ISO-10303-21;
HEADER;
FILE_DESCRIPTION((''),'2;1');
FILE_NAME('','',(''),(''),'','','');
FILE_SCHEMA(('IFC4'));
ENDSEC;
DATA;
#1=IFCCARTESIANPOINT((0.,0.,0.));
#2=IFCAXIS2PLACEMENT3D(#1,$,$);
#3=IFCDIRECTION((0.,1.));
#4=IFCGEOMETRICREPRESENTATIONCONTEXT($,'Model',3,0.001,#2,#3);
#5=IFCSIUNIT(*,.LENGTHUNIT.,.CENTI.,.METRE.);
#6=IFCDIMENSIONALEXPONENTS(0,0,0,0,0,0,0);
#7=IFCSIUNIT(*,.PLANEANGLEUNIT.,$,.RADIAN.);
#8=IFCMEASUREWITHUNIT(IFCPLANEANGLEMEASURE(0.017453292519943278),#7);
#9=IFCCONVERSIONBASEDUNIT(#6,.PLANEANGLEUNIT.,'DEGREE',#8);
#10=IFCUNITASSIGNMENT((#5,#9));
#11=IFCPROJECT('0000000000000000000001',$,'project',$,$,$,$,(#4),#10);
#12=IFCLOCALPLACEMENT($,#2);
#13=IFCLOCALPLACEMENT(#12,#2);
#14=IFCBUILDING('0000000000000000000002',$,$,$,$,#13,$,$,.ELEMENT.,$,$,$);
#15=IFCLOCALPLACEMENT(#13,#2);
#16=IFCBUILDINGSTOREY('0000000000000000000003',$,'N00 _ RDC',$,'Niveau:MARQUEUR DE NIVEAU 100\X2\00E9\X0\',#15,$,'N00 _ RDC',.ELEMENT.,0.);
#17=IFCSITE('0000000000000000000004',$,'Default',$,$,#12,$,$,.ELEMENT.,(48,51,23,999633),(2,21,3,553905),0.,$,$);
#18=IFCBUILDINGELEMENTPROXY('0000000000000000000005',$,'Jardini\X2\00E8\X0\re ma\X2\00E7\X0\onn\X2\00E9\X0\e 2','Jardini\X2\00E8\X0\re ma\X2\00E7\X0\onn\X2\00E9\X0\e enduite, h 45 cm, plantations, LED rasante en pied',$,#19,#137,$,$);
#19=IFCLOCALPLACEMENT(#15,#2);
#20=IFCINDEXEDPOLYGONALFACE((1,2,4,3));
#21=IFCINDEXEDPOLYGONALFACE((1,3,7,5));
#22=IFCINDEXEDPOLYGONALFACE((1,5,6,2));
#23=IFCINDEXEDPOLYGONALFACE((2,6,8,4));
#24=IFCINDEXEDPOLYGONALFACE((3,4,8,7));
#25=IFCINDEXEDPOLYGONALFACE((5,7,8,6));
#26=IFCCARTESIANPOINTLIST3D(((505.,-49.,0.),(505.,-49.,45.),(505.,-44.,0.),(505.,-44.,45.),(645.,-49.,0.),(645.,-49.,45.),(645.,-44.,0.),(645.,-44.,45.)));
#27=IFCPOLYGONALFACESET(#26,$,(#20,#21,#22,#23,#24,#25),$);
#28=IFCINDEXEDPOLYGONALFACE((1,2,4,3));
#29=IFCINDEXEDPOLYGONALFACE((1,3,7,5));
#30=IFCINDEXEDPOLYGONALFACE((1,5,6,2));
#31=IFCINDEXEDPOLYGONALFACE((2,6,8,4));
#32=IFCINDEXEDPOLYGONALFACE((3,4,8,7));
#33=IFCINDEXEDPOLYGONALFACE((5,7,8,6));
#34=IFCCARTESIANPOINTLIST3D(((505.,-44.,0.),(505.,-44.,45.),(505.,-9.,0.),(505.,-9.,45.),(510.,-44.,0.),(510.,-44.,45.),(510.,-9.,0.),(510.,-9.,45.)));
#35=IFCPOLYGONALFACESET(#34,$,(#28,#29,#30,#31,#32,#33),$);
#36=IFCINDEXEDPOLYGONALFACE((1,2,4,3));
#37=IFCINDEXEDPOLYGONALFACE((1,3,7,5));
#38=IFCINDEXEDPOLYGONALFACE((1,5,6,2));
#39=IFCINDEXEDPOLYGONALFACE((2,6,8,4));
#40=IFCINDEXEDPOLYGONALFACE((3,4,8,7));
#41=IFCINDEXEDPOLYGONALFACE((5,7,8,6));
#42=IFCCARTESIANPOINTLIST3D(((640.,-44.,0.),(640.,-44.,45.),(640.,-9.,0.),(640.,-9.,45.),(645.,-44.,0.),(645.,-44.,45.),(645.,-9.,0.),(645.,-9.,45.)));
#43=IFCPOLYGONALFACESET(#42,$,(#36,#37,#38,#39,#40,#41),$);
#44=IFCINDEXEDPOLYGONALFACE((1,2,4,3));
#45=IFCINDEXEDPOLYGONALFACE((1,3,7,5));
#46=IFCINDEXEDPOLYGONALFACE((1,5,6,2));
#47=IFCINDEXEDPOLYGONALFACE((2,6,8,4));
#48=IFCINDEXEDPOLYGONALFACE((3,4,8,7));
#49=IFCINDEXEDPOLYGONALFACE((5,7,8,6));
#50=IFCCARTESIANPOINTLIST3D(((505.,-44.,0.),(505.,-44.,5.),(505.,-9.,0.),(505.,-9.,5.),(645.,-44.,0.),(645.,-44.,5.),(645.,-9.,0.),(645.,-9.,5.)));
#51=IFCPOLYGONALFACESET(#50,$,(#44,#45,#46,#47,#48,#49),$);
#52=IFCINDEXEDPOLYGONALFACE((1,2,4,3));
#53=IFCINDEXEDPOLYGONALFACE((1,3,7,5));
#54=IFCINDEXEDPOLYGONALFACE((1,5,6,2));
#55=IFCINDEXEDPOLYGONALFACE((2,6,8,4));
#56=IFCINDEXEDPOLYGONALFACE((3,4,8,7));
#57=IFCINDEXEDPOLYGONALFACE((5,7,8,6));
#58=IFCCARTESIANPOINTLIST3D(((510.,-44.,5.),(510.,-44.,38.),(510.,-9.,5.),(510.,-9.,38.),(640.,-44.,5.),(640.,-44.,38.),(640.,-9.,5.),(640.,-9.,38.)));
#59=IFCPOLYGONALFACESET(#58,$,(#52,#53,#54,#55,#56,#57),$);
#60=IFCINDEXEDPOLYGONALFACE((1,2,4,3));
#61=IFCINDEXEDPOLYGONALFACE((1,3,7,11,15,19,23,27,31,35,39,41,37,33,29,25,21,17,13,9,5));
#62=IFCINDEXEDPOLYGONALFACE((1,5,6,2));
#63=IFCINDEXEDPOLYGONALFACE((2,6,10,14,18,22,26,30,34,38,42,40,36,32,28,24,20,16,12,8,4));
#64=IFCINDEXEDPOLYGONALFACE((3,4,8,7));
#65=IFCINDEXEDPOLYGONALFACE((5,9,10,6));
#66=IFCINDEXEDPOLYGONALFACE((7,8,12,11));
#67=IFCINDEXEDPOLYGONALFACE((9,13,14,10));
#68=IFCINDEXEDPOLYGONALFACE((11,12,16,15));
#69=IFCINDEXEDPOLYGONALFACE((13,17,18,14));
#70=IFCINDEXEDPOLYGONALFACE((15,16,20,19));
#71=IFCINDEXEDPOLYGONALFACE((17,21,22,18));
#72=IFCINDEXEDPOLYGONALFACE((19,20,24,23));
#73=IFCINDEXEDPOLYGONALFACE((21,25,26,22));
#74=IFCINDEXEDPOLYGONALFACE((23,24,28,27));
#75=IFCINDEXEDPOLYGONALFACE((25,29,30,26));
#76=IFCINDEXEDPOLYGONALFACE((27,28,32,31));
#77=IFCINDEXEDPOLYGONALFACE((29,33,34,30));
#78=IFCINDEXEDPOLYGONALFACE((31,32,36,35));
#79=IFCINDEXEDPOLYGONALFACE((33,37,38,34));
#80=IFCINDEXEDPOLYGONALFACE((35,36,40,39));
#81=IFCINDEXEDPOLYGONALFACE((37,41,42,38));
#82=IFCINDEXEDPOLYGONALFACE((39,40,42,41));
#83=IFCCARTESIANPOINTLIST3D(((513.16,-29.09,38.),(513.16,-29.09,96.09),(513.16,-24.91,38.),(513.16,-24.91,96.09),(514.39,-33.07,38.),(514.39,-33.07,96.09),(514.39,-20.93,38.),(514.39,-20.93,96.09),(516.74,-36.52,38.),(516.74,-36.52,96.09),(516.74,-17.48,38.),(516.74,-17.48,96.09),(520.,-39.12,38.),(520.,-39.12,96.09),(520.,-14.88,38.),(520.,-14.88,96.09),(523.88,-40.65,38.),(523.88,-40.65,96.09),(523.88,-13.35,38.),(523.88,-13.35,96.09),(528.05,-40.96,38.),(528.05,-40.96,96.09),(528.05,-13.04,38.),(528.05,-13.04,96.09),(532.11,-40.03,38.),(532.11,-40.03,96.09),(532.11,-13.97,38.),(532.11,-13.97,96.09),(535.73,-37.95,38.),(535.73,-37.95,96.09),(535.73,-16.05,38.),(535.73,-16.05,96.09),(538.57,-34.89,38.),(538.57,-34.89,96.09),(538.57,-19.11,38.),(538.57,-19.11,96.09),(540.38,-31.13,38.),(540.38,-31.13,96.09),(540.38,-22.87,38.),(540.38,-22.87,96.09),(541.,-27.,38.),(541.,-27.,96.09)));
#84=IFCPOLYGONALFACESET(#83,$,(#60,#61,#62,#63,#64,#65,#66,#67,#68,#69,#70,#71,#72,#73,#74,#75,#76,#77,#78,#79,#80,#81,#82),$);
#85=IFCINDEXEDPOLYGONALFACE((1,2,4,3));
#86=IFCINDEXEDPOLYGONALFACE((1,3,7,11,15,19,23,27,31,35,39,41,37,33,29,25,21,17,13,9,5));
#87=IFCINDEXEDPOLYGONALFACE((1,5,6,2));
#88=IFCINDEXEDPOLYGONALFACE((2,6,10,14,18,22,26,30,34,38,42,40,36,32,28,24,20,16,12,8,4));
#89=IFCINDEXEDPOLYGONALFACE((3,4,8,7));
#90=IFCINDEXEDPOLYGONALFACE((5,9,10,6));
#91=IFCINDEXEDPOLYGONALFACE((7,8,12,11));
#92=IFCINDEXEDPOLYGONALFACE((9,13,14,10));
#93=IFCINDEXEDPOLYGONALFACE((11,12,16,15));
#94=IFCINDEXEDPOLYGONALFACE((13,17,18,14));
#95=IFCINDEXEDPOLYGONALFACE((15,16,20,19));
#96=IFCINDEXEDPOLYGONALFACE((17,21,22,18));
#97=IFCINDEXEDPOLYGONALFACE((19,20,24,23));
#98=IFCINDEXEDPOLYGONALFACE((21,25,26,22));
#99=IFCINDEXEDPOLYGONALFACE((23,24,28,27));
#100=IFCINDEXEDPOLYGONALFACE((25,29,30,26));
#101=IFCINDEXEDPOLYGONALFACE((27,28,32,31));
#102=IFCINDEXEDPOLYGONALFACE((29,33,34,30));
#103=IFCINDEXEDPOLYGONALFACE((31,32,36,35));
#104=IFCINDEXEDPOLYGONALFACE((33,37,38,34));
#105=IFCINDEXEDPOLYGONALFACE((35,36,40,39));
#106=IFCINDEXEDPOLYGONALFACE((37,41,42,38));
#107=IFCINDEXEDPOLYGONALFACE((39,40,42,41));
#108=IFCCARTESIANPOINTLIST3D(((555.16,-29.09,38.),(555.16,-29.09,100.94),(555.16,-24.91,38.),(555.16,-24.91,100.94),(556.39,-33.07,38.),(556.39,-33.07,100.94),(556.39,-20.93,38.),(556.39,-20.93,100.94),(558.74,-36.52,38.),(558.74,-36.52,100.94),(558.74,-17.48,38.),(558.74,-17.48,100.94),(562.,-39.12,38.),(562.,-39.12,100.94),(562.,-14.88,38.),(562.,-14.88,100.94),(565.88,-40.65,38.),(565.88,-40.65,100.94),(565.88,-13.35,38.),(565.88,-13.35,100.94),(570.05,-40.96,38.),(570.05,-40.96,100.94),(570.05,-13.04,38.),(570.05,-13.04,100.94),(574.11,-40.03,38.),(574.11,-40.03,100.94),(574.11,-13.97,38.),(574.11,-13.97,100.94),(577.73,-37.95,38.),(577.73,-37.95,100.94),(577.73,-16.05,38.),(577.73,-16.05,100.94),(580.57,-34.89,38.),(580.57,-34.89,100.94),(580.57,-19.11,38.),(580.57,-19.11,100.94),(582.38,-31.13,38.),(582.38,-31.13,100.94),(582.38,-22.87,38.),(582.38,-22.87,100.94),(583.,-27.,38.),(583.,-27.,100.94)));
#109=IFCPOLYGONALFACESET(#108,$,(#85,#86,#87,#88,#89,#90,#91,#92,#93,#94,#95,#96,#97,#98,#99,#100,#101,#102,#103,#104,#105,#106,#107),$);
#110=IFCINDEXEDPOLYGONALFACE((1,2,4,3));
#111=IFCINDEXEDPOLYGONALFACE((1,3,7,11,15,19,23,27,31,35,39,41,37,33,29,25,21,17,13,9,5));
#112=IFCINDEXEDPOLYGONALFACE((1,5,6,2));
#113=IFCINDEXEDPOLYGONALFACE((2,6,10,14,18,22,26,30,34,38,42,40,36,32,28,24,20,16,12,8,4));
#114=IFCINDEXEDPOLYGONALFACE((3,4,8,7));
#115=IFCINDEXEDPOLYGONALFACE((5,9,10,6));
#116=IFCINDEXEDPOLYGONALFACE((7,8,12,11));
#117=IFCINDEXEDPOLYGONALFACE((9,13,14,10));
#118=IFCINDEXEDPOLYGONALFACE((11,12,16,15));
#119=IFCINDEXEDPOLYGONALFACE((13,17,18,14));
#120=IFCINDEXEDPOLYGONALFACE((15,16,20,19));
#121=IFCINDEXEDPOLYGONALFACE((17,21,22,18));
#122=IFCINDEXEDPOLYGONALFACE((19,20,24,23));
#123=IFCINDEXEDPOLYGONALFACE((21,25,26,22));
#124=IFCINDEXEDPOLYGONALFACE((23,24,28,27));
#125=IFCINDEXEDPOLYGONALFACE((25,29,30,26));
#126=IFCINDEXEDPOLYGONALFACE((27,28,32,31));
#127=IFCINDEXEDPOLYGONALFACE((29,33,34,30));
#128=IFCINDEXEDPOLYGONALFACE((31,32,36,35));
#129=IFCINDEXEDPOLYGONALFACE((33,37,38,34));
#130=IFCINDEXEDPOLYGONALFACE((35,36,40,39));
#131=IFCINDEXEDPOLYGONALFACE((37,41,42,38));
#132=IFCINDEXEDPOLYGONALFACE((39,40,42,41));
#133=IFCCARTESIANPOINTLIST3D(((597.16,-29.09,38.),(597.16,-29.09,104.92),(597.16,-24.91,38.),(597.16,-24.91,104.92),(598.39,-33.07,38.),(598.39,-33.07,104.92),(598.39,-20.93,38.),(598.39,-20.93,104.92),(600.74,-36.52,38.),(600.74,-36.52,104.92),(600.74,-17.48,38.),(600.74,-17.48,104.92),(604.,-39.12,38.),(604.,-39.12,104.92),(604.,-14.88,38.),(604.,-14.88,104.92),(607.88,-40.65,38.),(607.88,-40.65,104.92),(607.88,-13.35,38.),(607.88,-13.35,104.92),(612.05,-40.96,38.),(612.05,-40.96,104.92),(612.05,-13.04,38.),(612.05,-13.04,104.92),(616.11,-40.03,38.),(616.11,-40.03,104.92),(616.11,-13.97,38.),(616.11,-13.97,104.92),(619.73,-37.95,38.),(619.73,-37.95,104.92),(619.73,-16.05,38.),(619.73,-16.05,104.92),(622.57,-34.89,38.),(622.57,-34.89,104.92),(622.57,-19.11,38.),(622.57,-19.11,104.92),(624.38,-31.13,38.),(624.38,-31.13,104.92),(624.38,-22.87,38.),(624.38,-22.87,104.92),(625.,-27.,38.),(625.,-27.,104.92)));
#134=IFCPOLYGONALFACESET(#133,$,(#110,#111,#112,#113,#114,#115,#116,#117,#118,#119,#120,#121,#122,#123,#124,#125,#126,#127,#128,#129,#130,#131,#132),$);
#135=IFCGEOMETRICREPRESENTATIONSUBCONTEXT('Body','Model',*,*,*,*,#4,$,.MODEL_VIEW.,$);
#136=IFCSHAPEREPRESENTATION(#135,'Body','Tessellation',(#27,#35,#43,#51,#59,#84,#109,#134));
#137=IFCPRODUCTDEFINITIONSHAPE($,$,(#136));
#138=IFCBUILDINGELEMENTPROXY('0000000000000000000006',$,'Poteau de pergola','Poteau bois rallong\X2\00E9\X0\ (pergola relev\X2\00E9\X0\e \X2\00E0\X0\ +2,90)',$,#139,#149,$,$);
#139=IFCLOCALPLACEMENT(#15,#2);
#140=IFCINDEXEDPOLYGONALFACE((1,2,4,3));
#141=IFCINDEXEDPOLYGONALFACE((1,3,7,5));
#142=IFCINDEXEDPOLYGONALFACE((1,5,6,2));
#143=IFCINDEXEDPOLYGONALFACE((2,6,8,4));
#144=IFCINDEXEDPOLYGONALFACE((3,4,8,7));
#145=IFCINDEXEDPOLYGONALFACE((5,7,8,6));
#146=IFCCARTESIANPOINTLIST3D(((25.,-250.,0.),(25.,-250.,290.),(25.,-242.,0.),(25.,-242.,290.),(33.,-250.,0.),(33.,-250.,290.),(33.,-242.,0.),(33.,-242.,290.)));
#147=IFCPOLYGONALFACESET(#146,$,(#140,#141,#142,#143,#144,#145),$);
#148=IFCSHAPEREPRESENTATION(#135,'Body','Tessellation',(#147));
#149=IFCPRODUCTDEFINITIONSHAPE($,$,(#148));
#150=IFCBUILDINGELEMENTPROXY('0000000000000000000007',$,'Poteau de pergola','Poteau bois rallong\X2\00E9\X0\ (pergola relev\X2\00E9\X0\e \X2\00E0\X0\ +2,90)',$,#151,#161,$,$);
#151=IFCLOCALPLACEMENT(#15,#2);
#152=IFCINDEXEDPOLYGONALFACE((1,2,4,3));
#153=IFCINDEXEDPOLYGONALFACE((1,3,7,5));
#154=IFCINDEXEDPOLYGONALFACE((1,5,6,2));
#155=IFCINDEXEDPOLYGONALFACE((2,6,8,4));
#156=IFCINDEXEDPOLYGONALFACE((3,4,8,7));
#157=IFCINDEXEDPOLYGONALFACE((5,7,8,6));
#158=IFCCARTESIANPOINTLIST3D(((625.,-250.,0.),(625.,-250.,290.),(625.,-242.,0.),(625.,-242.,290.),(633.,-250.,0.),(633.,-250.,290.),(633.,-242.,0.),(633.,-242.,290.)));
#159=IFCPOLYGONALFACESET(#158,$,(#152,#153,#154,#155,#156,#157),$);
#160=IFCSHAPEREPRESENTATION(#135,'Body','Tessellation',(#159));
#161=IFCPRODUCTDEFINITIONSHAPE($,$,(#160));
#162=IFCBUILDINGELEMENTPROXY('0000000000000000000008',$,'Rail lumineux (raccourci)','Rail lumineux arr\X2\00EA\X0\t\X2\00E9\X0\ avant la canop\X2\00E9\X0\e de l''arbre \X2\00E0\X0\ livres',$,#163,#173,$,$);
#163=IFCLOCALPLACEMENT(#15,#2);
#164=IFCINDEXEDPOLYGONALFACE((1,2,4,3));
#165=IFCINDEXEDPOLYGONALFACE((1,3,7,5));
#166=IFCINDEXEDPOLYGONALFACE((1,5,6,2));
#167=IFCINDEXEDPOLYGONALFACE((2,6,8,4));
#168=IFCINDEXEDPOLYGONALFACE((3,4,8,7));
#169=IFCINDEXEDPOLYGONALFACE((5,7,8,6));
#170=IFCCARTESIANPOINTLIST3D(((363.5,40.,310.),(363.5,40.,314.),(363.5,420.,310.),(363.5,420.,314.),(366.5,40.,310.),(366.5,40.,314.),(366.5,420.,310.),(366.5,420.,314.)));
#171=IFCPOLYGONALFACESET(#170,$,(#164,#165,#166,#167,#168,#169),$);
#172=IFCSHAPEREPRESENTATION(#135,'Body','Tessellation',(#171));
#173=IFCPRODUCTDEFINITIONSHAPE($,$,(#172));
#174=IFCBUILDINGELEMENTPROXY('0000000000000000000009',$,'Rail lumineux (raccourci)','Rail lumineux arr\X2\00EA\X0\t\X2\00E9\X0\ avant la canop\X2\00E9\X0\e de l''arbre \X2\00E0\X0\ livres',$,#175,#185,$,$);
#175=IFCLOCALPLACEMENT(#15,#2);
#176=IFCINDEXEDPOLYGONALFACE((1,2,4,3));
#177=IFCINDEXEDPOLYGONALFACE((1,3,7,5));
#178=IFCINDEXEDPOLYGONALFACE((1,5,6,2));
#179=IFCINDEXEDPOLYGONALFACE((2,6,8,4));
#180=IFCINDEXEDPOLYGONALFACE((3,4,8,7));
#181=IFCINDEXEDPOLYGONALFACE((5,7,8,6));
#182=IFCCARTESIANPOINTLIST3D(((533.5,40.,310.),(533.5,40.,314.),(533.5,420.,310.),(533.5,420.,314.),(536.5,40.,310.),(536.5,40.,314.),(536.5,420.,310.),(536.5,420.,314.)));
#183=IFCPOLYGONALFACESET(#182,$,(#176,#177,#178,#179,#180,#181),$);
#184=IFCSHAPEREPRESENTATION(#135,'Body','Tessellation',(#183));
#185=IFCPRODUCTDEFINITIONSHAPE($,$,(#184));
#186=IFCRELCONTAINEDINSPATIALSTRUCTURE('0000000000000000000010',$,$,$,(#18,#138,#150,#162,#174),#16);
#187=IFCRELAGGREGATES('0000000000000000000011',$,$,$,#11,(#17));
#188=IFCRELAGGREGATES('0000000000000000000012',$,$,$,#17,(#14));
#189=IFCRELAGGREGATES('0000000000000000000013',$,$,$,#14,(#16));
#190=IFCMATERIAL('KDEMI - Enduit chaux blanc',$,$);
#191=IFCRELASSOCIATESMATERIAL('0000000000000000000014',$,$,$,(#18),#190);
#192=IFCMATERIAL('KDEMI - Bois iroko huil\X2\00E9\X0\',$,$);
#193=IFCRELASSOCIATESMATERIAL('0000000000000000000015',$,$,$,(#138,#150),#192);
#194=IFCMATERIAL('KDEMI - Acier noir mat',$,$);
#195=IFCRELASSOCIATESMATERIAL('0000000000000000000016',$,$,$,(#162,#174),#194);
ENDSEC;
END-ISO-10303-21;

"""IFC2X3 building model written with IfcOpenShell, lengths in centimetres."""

from ifc_helpers import new_model, entity, si_unit, converted_unit, direction, frame, frame_2d, origin, origin_with_axes, place, context, subcontext, project, spatial, rectangle, circle, extrude, material, element, save


model = new_model("IFC2X3")

# Units and contexts
model_context = context("Model", 3, precision=0.001, world=origin(), true_north=direction((0.0, 1.0)))
body_context = subcontext(model_context, "Body", "Model", "MODEL_VIEW")
ifc_project = project(units=[si_unit("LENGTHUNIT", "METRE", prefix="CENTI"), converted_unit("PLANEANGLEUNIT", "DEGREE", entity("IfcPlaneAngleMeasure", 0.017453292519943278), si_unit("PLANEANGLEUNIT", "RADIAN"), dimensions=[0, 0, 0, 0, 0, 0, 0])], contexts=[model_context])

# Site, building, storey
site_placement = place(None, origin())
site = spatial("IfcSite", under=ifc_project, at=site_placement, Name="Default", CompositionType="ELEMENT", RefLatitude=(48, 51, 23, 999633), RefLongitude=(2, 21, 3, 553905), RefElevation=0.0)
building_placement = place(site_placement, origin())
building = spatial("IfcBuilding", under=site, at=building_placement, CompositionType="ELEMENT")
storey_placement = place(building_placement, origin())
storey = spatial("IfcBuildingStorey", under=building, at=storey_placement, Name="N00 _ RDC", ObjectType="Niveau:MARQUEUR DE NIVEAU 100é", LongName="N00 _ RDC", CompositionType="ELEMENT", Elevation=0.0)

# Shared definitions
ifc_material_1 = material(Name="KDEMI - Acier noir mat")

# Shared definitions
ifc_material_2 = material(Name="KDEMI - Bois iroko huilé")

# Building element proxies
ifc_material_3 = material(Name="KDEMI - Enduit chaux blanc")
proxy_1_placement = place(storey_placement, origin_with_axes())
element("IfcBuildingElementProxy", 1, at=proxy_1_placement, inside=storey, material=ifc_material_3, Name="Jardinière maçonnée 2", Description="Jardinière maçonnée enduite, h 45 cm, plantations, LED rasante en pied", context=body_context, shape_type="SweptSolid", body=[
    extrude(rectangle(XDim=140.0, YDim=5.0, at=frame_2d((575.0, -46.5))), origin(), (0.0, 0.0, 1.0), 45.0),
    extrude(rectangle(XDim=5.0, YDim=35.0, at=frame_2d((507.5, -26.5))), origin(), (0.0, 0.0, 1.0), 45.0),
    extrude(rectangle(XDim=5.0, YDim=35.0, at=frame_2d((642.5, -26.5))), origin(), (0.0, 0.0, 1.0), 45.0),
    extrude(rectangle(XDim=140.0, YDim=35.0, at=frame_2d((575.0, -26.5))), origin(), (0.0, 0.0, 1.0), 5.0),
    extrude(rectangle(XDim=130.0, YDim=35.0, at=frame_2d((575.0, -26.5))), frame((0.0, 0.0, 5.0)), (0.0, 0.0, 1.0), 33.0),
    extrude(circle(Radius=14.0, at=frame_2d((527.0, -27.0))), frame((0.0, 0.0, 38.0)), (0.0, 0.0, 1.0), 58.09),
    extrude(circle(Radius=14.0, at=frame_2d((569.0, -27.0))), frame((0.0, 0.0, 38.0)), (0.0, 0.0, 1.0), 62.94),
    extrude(circle(Radius=14.0, at=frame_2d((611.0, -27.0))), frame((0.0, 0.0, 38.0)), (0.0, 0.0, 1.0), 66.92),
])
proxy_2_placement = place(storey_placement, origin_with_axes())
element("IfcBuildingElementProxy", 2, at=proxy_2_placement, inside=storey, material=ifc_material_2, Name="Poteau de pergola", Description="Poteau bois rallongé (pergola relevée à +2,90)", context=body_context, shape_type="SweptSolid", body=[
    extrude(rectangle(XDim=8.0, YDim=8.0, at=frame_2d((29.0, -246.0))), origin(), (0.0, 0.0, 1.0), 290.0),
])
proxy_3_placement = place(storey_placement, origin_with_axes())
element("IfcBuildingElementProxy", 3, at=proxy_3_placement, inside=storey, material=ifc_material_2, Name="Poteau de pergola", Description="Poteau bois rallongé (pergola relevée à +2,90)", context=body_context, shape_type="SweptSolid", body=[
    extrude(rectangle(XDim=8.0, YDim=8.0, at=frame_2d((629.0, -246.0))), origin(), (0.0, 0.0, 1.0), 290.0),
])
proxy_4_placement = place(storey_placement, origin_with_axes())
element("IfcBuildingElementProxy", 4, at=proxy_4_placement, inside=storey, material=ifc_material_1, Name="Rail lumineux (raccourci)", Description="Rail lumineux arrêté avant la canopée de l'arbre à livres", context=body_context, shape_type="SweptSolid", body=[
    extrude(rectangle(XDim=3.0, YDim=380.0, at=frame_2d((365.0, 230.0))), frame((0.0, 0.0, 310.0)), (0.0, 0.0, 1.0), 4.0),
])
proxy_5_placement = place(storey_placement, origin_with_axes())
element("IfcBuildingElementProxy", 5, at=proxy_5_placement, inside=storey, material=ifc_material_1, Name="Rail lumineux (raccourci)", Description="Rail lumineux arrêté avant la canopée de l'arbre à livres", context=body_context, shape_type="SweptSolid", body=[
    extrude(rectangle(XDim=3.0, YDim=380.0, at=frame_2d((535.0, 230.0))), frame((0.0, 0.0, 310.0)), (0.0, 0.0, 1.0), 4.0),
])

save(model, "model.ifc")
